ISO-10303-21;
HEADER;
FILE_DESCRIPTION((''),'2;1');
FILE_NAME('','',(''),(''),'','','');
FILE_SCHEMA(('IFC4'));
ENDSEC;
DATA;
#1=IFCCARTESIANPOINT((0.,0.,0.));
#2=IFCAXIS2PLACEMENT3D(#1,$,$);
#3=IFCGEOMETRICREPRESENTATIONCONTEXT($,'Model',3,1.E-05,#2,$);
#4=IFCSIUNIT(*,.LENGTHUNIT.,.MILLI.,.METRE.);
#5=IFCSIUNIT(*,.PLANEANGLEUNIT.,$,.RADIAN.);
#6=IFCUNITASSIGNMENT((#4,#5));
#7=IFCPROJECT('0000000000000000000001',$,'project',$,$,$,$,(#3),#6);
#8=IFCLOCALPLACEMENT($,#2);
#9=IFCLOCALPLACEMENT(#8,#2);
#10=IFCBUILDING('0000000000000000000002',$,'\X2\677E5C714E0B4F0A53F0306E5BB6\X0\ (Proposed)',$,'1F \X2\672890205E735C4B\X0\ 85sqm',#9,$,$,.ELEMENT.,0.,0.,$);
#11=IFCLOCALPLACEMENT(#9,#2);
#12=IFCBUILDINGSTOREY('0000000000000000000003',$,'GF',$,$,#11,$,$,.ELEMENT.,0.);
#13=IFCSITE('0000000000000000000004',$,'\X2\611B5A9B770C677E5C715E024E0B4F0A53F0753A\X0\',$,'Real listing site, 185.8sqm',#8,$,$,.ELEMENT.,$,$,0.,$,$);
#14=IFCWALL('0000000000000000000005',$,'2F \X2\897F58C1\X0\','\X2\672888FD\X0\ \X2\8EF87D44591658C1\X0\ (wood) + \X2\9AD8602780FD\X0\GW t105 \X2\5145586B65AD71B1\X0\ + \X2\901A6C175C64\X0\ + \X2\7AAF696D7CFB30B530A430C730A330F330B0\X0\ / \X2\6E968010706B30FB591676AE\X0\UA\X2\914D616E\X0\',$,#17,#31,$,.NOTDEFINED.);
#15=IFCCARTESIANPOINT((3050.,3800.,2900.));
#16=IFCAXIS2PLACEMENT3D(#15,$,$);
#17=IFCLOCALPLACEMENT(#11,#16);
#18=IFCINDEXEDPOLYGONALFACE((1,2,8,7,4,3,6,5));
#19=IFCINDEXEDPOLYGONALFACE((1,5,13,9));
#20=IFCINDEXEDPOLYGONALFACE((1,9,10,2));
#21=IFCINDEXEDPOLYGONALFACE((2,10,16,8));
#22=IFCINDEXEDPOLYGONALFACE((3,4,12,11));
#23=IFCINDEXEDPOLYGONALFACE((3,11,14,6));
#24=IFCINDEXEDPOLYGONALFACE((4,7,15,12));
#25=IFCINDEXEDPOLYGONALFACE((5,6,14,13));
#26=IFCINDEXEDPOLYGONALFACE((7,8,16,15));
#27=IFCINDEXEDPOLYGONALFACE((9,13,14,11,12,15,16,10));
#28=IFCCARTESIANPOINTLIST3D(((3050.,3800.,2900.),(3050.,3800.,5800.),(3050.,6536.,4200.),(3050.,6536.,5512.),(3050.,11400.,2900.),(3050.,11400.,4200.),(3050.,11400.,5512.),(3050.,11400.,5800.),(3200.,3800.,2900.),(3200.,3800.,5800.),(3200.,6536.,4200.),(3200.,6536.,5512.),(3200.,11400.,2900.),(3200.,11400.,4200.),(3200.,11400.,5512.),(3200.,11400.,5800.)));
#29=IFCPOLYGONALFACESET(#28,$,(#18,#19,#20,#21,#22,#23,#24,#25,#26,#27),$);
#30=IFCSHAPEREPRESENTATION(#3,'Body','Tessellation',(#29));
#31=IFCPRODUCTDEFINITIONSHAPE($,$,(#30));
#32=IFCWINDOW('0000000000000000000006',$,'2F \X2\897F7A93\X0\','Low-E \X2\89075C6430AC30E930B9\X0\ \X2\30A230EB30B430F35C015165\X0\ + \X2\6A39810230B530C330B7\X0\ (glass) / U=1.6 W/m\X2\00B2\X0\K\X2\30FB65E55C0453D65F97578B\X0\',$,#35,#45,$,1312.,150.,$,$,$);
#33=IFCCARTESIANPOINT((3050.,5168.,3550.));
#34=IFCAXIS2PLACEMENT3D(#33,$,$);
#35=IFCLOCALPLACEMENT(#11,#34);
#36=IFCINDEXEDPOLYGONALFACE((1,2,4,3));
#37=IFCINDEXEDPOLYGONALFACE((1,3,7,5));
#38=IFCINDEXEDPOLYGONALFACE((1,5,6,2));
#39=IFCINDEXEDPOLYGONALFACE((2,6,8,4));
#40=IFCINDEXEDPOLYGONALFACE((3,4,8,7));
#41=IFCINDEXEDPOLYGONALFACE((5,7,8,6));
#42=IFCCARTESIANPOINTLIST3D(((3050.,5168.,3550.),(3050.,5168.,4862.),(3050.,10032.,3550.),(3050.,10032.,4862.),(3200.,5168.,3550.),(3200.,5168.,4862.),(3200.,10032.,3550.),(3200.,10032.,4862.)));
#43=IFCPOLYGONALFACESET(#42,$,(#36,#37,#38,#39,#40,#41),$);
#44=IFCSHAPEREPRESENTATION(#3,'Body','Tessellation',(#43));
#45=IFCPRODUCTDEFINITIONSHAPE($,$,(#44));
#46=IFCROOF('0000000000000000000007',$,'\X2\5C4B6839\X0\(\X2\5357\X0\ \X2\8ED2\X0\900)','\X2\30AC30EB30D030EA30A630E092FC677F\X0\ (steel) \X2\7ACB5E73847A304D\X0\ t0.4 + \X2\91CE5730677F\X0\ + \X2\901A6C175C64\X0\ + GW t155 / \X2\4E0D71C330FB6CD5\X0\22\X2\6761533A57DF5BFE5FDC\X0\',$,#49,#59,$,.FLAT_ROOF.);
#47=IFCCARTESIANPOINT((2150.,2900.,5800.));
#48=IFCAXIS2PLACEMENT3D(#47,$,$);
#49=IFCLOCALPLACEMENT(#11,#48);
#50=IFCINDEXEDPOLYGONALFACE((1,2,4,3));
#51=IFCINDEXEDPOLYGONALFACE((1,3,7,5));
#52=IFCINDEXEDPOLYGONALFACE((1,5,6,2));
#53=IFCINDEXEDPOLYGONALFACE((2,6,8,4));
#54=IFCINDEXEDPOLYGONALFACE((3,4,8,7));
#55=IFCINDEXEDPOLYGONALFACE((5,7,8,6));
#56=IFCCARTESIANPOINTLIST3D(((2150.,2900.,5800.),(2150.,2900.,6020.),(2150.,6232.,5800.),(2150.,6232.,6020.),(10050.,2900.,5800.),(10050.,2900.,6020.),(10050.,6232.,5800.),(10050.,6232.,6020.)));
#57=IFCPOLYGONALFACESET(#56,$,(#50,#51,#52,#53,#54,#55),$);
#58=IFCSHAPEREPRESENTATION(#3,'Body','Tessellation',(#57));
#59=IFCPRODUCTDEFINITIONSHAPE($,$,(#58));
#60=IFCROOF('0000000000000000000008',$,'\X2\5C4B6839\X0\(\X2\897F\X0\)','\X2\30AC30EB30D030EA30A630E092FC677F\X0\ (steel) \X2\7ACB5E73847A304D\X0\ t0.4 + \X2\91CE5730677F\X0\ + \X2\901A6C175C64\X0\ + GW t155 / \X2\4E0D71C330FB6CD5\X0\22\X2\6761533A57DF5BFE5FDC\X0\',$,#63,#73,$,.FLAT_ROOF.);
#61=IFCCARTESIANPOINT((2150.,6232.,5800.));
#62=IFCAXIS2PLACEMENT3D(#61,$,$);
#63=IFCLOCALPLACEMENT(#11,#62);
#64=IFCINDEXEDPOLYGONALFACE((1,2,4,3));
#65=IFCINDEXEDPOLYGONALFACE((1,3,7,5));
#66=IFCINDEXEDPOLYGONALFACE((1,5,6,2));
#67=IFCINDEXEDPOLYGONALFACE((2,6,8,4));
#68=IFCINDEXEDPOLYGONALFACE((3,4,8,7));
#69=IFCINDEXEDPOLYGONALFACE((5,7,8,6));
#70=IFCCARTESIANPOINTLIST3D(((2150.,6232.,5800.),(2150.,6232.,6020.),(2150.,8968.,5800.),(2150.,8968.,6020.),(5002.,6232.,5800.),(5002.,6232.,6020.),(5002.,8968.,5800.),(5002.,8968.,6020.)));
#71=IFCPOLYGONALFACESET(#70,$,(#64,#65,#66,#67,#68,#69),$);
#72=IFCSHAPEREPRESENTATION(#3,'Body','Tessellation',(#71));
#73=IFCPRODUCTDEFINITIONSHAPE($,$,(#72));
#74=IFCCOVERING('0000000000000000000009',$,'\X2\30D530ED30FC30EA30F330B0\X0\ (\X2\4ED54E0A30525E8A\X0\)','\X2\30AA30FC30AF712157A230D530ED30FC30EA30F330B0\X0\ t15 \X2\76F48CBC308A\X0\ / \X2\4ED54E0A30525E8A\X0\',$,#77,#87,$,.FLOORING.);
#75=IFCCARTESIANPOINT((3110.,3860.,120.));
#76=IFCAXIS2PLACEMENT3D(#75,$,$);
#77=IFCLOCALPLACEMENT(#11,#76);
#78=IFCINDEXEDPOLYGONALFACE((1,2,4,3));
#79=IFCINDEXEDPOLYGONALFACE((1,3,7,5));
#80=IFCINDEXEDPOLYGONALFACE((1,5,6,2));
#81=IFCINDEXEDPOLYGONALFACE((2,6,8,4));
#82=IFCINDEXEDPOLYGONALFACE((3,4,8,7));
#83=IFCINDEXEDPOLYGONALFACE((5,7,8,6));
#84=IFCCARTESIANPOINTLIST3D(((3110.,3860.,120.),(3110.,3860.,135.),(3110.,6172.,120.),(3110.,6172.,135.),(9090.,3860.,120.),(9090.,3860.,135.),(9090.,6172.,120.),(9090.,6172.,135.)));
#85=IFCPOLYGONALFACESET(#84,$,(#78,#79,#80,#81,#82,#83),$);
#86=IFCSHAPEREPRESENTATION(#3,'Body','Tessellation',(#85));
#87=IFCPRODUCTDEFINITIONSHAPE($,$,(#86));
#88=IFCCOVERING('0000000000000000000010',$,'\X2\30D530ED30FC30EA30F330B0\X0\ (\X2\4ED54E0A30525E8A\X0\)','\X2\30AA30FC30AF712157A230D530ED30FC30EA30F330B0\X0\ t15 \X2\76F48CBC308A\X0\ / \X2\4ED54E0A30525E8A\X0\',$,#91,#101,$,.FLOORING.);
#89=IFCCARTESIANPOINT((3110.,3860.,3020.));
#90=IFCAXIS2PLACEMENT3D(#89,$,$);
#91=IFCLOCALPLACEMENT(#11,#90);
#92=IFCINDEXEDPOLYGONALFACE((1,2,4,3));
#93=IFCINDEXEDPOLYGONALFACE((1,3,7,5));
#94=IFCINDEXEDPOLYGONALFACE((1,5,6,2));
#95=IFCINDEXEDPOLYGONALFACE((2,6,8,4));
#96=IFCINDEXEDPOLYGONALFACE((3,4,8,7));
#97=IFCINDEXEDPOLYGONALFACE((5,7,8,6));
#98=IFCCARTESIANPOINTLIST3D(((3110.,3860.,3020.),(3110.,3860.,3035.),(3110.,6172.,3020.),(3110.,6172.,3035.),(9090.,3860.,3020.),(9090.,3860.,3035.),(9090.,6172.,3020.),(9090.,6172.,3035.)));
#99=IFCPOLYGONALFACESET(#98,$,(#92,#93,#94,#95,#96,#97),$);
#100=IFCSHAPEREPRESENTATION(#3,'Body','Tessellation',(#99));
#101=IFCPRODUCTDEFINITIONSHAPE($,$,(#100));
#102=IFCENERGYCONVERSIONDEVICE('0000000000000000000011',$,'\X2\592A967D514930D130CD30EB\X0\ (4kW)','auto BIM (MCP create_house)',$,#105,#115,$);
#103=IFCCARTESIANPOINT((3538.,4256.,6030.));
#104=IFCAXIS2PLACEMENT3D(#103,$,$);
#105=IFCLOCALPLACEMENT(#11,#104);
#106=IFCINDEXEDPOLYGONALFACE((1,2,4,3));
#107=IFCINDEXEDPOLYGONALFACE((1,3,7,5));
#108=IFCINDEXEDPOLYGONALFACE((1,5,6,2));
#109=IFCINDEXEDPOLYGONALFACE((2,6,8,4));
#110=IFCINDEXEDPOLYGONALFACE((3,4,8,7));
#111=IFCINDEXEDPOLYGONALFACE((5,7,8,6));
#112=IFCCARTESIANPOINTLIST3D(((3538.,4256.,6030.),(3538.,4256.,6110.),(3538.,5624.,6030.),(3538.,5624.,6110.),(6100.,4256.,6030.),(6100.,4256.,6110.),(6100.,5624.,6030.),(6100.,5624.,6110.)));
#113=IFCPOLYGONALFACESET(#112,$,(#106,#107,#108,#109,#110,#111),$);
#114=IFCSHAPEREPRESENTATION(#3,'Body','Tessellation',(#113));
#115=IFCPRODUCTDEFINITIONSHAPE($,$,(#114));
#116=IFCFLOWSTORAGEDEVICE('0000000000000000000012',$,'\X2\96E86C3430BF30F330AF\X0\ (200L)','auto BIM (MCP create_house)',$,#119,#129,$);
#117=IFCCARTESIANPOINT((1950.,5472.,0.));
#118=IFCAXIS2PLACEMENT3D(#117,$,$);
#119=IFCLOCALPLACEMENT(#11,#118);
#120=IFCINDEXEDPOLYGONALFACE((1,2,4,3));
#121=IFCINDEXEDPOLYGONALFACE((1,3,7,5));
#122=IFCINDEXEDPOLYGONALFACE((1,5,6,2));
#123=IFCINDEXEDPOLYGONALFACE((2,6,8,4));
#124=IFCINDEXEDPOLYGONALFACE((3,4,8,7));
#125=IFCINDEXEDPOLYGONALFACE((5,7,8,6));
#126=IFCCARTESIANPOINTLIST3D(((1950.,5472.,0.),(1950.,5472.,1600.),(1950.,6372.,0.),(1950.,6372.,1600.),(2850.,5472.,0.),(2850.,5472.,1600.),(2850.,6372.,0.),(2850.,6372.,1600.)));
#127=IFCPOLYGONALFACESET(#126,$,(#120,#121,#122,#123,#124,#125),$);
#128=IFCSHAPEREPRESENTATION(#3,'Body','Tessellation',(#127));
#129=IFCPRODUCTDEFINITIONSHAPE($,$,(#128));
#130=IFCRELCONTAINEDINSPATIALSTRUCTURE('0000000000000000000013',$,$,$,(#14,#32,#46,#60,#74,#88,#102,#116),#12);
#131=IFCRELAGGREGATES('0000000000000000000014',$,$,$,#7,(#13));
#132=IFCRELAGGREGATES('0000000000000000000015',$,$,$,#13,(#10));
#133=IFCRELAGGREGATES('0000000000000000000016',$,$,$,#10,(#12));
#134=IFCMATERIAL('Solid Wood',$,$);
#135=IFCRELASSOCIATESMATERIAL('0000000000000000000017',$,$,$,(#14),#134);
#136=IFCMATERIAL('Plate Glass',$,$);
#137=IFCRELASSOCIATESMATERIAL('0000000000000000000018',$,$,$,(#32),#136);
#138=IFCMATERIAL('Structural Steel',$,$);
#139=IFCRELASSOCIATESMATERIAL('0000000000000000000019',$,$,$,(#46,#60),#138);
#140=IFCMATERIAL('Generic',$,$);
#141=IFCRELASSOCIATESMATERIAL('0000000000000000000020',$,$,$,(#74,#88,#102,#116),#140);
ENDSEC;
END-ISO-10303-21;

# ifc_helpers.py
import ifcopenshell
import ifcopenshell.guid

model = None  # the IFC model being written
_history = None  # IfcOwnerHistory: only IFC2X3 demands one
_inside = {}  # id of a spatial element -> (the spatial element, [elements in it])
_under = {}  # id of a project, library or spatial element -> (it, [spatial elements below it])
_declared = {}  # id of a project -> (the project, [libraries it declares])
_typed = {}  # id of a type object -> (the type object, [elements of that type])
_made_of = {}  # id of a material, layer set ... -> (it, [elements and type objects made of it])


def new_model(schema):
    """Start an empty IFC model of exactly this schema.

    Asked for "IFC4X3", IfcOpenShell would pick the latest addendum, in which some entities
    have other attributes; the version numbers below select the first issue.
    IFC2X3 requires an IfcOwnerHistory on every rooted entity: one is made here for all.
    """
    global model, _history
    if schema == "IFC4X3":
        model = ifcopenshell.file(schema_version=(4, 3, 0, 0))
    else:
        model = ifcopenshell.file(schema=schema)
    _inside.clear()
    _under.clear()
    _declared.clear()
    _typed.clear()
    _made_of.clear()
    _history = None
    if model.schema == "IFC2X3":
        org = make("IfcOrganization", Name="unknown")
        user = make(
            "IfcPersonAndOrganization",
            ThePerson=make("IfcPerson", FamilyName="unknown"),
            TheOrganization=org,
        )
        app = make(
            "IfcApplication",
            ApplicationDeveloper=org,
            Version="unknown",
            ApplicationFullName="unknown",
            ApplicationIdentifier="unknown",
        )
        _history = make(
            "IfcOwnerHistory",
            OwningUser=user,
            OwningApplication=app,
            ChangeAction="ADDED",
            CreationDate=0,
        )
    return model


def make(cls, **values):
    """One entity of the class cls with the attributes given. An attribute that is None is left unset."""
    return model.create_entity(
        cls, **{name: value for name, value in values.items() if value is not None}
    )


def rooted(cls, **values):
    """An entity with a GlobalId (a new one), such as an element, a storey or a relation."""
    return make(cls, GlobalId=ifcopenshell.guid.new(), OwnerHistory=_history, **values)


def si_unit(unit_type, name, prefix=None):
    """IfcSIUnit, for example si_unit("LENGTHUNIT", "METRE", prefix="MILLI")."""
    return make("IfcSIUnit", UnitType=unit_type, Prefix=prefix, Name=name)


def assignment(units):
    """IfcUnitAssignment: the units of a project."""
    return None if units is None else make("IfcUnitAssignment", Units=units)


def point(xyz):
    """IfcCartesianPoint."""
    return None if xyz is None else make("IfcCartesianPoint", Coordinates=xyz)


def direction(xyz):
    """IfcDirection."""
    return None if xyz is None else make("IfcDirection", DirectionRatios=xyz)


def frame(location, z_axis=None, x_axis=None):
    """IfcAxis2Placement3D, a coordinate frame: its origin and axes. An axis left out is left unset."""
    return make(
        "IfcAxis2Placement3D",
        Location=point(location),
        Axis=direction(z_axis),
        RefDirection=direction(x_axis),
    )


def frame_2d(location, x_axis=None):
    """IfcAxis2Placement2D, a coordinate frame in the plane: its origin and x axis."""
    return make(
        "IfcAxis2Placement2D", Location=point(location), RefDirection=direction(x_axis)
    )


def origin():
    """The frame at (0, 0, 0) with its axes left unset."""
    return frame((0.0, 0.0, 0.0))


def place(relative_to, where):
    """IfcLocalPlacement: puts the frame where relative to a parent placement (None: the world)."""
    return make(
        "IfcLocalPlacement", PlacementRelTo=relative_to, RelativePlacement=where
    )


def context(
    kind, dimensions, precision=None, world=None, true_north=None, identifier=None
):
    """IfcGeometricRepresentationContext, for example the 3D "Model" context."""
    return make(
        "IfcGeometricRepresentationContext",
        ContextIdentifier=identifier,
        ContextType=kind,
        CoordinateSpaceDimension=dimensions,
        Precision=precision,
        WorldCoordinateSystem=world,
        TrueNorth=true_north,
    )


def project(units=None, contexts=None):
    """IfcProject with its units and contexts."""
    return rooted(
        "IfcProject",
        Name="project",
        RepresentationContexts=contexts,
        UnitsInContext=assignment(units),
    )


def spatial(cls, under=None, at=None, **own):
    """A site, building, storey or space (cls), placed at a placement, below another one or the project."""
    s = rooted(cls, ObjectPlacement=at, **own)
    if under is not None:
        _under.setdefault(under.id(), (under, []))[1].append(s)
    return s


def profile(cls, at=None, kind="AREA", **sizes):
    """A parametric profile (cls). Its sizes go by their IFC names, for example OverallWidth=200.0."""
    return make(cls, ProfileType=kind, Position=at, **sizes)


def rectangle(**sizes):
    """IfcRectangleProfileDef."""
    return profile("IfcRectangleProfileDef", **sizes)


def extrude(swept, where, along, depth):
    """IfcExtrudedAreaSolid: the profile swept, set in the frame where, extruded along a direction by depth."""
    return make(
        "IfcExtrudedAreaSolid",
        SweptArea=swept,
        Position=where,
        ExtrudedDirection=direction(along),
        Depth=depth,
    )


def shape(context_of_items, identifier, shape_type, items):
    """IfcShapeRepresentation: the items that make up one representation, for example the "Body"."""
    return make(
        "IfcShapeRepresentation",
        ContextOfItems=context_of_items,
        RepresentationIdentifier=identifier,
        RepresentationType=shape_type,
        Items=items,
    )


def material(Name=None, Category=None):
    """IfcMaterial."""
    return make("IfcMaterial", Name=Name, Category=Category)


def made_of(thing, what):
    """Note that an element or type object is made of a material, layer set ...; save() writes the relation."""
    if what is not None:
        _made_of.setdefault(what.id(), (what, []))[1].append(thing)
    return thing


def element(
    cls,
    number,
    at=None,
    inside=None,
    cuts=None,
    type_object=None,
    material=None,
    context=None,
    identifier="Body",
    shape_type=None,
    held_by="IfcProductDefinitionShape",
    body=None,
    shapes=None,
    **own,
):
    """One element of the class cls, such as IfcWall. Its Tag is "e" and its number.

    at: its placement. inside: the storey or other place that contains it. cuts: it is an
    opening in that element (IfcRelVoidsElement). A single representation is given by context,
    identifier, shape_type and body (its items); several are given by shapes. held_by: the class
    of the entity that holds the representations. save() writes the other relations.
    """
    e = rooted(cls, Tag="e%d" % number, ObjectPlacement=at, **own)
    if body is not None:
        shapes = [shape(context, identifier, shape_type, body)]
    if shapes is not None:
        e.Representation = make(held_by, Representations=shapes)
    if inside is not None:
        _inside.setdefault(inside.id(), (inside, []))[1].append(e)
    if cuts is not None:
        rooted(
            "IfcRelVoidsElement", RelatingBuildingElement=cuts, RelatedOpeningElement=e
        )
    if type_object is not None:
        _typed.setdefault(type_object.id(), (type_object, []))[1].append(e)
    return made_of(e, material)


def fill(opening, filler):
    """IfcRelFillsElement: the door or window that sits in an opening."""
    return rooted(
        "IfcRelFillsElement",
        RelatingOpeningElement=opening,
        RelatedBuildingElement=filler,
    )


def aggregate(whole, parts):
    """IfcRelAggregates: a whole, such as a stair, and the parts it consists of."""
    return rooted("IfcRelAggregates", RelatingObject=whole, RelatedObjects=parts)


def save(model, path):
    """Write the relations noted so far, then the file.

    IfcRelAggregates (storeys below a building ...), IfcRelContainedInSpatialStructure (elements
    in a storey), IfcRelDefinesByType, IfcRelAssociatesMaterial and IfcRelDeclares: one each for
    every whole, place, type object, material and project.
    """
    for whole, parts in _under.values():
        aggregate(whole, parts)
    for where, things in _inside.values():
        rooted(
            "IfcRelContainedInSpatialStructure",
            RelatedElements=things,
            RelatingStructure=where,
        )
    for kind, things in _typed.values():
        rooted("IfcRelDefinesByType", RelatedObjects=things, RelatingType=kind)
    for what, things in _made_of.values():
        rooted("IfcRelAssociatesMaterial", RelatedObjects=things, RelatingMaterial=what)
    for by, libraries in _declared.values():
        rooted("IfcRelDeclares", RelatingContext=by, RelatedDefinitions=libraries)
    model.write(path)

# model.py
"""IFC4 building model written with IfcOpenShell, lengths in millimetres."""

from ifc_helpers import new_model, si_unit, frame, frame_2d, origin, place, context, project, spatial, rectangle, extrude, material, element, fill, save


model = new_model("IFC4")

# Units and contexts
model_context = context("Model", 3, precision=1e-05, world=origin())
ifc_project = project(units=[si_unit("LENGTHUNIT", "METRE", prefix="MILLI"), si_unit("PLANEANGLEUNIT", "RADIAN")], contexts=[model_context])

# Site, building, storey
site_placement = place(None, origin())
site = spatial("IfcSite", under=ifc_project, at=site_placement, Name="愛媛県松山市下伊台町", ObjectType="Real listing site, 185.8sqm", CompositionType="ELEMENT", RefElevation=0.0)
building_placement = place(site_placement, origin())
building = spatial("IfcBuilding", under=site, at=building_placement, Name="松山下伊台の家 (Proposed)", ObjectType="1F 木造平屋 85sqm", CompositionType="ELEMENT", ElevationOfRefHeight=0.0, ElevationOfTerrain=0.0)
storey_placement = place(building_placement, origin())
storey = spatial("IfcBuildingStorey", under=building, at=storey_placement, Name="GF", CompositionType="ELEMENT", Elevation=0.0)

# Shared definitions
ifc_material_1 = material(Name="Solid Wood")
ifc_material_2 = material(Name="Generic")

# Shared definitions
ifc_material_3 = material(Name="Plate Glass")

# Wall, opening, window
wall_1_placement = place(storey_placement, frame((3050.0, 3800.0, 2900.0)))
wall_1 = element("IfcWall", 1, at=wall_1_placement, inside=storey, material=ifc_material_1, Name="2F 西壁", Description="木製 軸組外壁 (wood) + 高性能GW t105 充填断熱 + 通気層 + 窯業系サイディング / 準耐火・外皮UA配慮", PredefinedType="NOTDEFINED", context=model_context, shape_type="SweptSolid", body=[
    extrude(rectangle(XDim=150.0, YDim=7600.0, at=frame_2d((75.0, 3800.0))), frame((3050.0, 3800.0, 2900.0)), (0.0, 0.0, 1.0), 2900.0),
])
opening_1_placement = place(storey_placement, frame((3050.0, 5168.0, 3550.0)))
opening_1 = element("IfcOpeningElement", 2, at=opening_1_placement, cuts=wall_1, PredefinedType="NOTDEFINED", context=model_context, shape_type="SweptSolid", body=[
    extrude(rectangle(XDim=150.0, YDim=4864.0, at=frame_2d((75.0, 2432.0))), frame((3050.0, 5168.0, 3550.0)), (0.0, 0.0, 1.0), 1312.0),
])
window_1_placement = place(storey_placement, frame((3050.0, 5168.0, 3550.0)))
window_1 = element("IfcWindow", 3, at=window_1_placement, inside=storey, material=ifc_material_3, Name="2F 西窓", Description="Low-E 複層ガラス アルゴン封入 + 樹脂サッシ (glass) / U=1.6 W/m²K・日射取得型", OverallHeight=1312.0, OverallWidth=150.0, context=model_context, shape_type="SweptSolid", body=[
    extrude(rectangle(XDim=150.0, YDim=4864.0, at=frame_2d((75.0, 2432.0))), frame((3050.0, 5168.0, 3550.0)), (0.0, 0.0, 1.0), 1312.0),
])
fill(opening_1, window_1)

# Roofs
ifc_material_4 = material(Name="Structural Steel")
roof_1_placement = place(storey_placement, frame((2150.0, 2900.0, 5800.0)))
element("IfcRoof", 4, at=roof_1_placement, inside=storey, material=ifc_material_4, Name="屋根(南 軒900)", Description="ガルバリウム鋼板 (steel) 立平葺き t0.4 + 野地板 + 通気層 + GW t155 / 不燃・法22条区域対応", PredefinedType="FLAT_ROOF", context=model_context, shape_type="SweptSolid", body=[
    extrude(rectangle(XDim=7900.0, YDim=3332.0, at=frame_2d((3950.0, 1666.0))), frame((2150.0, 2900.0, 5800.0)), (0.0, 0.0, 1.0), 220.0),
])
roof_2_placement = place(storey_placement, frame((2150.0, 6232.0, 5800.0)))
element("IfcRoof", 5, at=roof_2_placement, inside=storey, material=ifc_material_4, Name="屋根(西)", Description="ガルバリウム鋼板 (steel) 立平葺き t0.4 + 野地板 + 通気層 + GW t155 / 不燃・法22条区域対応", PredefinedType="FLAT_ROOF", context=model_context, shape_type="SweptSolid", body=[
    extrude(rectangle(XDim=2852.0, YDim=2736.0, at=frame_2d((1426.0, 1368.0))), frame((2150.0, 6232.0, 5800.0)), (0.0, 0.0, 1.0), 220.0),
])

# Coverings
covering_1_placement = place(storey_placement, frame((3110.0, 3860.0, 120.0)))
element("IfcCovering", 6, at=covering_1_placement, inside=storey, material=ifc_material_2, Name="フローリング (仕上げ床)", Description="オーク無垢フローリング t15 直貼り / 仕上げ床", PredefinedType="FLOORING", context=model_context, shape_type="SweptSolid", body=[
    extrude(rectangle(XDim=5980.0, YDim=2312.0, at=frame_2d((2990.0, 1156.0))), frame((3110.0, 3860.0, 120.0)), (0.0, 0.0, 1.0), 15.0),
])
covering_2_placement = place(storey_placement, frame((3110.0, 3860.0, 3020.0)))
element("IfcCovering", 7, at=covering_2_placement, inside=storey, material=ifc_material_2, Name="フローリング (仕上げ床)", Description="オーク無垢フローリング t15 直貼り / 仕上げ床", PredefinedType="FLOORING", context=model_context, shape_type="SweptSolid", body=[
    extrude(rectangle(XDim=5980.0, YDim=2312.0, at=frame_2d((2990.0, 1156.0))), frame((3110.0, 3860.0, 3020.0)), (0.0, 0.0, 1.0), 15.0),
])

# Energy conversion device
energy_conversion_device_placement = place(storey_placement, frame((3538.0, 4256.0, 6030.0)))
element("IfcEnergyConversionDevice", 8, at=energy_conversion_device_placement, inside=storey, material=ifc_material_2, Name="太陽光パネル (4kW)", Description="auto BIM (MCP create_house)", context=model_context, shape_type="SweptSolid", body=[
    extrude(rectangle(XDim=2562.0, YDim=1368.0, at=frame_2d((1281.0, 684.0))), frame((3538.0, 4256.0, 6030.0)), (0.0, 0.0, 1.0), 80.0),
])

# Flow storage device
flow_storage_device_placement = place(storey_placement, frame((1950.0, 5472.0, 0.0)))
element("IfcFlowStorageDevice", 9, at=flow_storage_device_placement, inside=storey, material=ifc_material_2, Name="雨水タンク (200L)", Description="auto BIM (MCP create_house)", context=model_context, shape_type="SweptSolid", body=[
    extrude(rectangle(XDim=900.0, YDim=900.0, at=frame_2d((450.0, 450.0))), frame((1950.0, 5472.0, 0.0)), (0.0, 0.0, 1.0), 1600.0),
])

save(model, "model.ifc")
